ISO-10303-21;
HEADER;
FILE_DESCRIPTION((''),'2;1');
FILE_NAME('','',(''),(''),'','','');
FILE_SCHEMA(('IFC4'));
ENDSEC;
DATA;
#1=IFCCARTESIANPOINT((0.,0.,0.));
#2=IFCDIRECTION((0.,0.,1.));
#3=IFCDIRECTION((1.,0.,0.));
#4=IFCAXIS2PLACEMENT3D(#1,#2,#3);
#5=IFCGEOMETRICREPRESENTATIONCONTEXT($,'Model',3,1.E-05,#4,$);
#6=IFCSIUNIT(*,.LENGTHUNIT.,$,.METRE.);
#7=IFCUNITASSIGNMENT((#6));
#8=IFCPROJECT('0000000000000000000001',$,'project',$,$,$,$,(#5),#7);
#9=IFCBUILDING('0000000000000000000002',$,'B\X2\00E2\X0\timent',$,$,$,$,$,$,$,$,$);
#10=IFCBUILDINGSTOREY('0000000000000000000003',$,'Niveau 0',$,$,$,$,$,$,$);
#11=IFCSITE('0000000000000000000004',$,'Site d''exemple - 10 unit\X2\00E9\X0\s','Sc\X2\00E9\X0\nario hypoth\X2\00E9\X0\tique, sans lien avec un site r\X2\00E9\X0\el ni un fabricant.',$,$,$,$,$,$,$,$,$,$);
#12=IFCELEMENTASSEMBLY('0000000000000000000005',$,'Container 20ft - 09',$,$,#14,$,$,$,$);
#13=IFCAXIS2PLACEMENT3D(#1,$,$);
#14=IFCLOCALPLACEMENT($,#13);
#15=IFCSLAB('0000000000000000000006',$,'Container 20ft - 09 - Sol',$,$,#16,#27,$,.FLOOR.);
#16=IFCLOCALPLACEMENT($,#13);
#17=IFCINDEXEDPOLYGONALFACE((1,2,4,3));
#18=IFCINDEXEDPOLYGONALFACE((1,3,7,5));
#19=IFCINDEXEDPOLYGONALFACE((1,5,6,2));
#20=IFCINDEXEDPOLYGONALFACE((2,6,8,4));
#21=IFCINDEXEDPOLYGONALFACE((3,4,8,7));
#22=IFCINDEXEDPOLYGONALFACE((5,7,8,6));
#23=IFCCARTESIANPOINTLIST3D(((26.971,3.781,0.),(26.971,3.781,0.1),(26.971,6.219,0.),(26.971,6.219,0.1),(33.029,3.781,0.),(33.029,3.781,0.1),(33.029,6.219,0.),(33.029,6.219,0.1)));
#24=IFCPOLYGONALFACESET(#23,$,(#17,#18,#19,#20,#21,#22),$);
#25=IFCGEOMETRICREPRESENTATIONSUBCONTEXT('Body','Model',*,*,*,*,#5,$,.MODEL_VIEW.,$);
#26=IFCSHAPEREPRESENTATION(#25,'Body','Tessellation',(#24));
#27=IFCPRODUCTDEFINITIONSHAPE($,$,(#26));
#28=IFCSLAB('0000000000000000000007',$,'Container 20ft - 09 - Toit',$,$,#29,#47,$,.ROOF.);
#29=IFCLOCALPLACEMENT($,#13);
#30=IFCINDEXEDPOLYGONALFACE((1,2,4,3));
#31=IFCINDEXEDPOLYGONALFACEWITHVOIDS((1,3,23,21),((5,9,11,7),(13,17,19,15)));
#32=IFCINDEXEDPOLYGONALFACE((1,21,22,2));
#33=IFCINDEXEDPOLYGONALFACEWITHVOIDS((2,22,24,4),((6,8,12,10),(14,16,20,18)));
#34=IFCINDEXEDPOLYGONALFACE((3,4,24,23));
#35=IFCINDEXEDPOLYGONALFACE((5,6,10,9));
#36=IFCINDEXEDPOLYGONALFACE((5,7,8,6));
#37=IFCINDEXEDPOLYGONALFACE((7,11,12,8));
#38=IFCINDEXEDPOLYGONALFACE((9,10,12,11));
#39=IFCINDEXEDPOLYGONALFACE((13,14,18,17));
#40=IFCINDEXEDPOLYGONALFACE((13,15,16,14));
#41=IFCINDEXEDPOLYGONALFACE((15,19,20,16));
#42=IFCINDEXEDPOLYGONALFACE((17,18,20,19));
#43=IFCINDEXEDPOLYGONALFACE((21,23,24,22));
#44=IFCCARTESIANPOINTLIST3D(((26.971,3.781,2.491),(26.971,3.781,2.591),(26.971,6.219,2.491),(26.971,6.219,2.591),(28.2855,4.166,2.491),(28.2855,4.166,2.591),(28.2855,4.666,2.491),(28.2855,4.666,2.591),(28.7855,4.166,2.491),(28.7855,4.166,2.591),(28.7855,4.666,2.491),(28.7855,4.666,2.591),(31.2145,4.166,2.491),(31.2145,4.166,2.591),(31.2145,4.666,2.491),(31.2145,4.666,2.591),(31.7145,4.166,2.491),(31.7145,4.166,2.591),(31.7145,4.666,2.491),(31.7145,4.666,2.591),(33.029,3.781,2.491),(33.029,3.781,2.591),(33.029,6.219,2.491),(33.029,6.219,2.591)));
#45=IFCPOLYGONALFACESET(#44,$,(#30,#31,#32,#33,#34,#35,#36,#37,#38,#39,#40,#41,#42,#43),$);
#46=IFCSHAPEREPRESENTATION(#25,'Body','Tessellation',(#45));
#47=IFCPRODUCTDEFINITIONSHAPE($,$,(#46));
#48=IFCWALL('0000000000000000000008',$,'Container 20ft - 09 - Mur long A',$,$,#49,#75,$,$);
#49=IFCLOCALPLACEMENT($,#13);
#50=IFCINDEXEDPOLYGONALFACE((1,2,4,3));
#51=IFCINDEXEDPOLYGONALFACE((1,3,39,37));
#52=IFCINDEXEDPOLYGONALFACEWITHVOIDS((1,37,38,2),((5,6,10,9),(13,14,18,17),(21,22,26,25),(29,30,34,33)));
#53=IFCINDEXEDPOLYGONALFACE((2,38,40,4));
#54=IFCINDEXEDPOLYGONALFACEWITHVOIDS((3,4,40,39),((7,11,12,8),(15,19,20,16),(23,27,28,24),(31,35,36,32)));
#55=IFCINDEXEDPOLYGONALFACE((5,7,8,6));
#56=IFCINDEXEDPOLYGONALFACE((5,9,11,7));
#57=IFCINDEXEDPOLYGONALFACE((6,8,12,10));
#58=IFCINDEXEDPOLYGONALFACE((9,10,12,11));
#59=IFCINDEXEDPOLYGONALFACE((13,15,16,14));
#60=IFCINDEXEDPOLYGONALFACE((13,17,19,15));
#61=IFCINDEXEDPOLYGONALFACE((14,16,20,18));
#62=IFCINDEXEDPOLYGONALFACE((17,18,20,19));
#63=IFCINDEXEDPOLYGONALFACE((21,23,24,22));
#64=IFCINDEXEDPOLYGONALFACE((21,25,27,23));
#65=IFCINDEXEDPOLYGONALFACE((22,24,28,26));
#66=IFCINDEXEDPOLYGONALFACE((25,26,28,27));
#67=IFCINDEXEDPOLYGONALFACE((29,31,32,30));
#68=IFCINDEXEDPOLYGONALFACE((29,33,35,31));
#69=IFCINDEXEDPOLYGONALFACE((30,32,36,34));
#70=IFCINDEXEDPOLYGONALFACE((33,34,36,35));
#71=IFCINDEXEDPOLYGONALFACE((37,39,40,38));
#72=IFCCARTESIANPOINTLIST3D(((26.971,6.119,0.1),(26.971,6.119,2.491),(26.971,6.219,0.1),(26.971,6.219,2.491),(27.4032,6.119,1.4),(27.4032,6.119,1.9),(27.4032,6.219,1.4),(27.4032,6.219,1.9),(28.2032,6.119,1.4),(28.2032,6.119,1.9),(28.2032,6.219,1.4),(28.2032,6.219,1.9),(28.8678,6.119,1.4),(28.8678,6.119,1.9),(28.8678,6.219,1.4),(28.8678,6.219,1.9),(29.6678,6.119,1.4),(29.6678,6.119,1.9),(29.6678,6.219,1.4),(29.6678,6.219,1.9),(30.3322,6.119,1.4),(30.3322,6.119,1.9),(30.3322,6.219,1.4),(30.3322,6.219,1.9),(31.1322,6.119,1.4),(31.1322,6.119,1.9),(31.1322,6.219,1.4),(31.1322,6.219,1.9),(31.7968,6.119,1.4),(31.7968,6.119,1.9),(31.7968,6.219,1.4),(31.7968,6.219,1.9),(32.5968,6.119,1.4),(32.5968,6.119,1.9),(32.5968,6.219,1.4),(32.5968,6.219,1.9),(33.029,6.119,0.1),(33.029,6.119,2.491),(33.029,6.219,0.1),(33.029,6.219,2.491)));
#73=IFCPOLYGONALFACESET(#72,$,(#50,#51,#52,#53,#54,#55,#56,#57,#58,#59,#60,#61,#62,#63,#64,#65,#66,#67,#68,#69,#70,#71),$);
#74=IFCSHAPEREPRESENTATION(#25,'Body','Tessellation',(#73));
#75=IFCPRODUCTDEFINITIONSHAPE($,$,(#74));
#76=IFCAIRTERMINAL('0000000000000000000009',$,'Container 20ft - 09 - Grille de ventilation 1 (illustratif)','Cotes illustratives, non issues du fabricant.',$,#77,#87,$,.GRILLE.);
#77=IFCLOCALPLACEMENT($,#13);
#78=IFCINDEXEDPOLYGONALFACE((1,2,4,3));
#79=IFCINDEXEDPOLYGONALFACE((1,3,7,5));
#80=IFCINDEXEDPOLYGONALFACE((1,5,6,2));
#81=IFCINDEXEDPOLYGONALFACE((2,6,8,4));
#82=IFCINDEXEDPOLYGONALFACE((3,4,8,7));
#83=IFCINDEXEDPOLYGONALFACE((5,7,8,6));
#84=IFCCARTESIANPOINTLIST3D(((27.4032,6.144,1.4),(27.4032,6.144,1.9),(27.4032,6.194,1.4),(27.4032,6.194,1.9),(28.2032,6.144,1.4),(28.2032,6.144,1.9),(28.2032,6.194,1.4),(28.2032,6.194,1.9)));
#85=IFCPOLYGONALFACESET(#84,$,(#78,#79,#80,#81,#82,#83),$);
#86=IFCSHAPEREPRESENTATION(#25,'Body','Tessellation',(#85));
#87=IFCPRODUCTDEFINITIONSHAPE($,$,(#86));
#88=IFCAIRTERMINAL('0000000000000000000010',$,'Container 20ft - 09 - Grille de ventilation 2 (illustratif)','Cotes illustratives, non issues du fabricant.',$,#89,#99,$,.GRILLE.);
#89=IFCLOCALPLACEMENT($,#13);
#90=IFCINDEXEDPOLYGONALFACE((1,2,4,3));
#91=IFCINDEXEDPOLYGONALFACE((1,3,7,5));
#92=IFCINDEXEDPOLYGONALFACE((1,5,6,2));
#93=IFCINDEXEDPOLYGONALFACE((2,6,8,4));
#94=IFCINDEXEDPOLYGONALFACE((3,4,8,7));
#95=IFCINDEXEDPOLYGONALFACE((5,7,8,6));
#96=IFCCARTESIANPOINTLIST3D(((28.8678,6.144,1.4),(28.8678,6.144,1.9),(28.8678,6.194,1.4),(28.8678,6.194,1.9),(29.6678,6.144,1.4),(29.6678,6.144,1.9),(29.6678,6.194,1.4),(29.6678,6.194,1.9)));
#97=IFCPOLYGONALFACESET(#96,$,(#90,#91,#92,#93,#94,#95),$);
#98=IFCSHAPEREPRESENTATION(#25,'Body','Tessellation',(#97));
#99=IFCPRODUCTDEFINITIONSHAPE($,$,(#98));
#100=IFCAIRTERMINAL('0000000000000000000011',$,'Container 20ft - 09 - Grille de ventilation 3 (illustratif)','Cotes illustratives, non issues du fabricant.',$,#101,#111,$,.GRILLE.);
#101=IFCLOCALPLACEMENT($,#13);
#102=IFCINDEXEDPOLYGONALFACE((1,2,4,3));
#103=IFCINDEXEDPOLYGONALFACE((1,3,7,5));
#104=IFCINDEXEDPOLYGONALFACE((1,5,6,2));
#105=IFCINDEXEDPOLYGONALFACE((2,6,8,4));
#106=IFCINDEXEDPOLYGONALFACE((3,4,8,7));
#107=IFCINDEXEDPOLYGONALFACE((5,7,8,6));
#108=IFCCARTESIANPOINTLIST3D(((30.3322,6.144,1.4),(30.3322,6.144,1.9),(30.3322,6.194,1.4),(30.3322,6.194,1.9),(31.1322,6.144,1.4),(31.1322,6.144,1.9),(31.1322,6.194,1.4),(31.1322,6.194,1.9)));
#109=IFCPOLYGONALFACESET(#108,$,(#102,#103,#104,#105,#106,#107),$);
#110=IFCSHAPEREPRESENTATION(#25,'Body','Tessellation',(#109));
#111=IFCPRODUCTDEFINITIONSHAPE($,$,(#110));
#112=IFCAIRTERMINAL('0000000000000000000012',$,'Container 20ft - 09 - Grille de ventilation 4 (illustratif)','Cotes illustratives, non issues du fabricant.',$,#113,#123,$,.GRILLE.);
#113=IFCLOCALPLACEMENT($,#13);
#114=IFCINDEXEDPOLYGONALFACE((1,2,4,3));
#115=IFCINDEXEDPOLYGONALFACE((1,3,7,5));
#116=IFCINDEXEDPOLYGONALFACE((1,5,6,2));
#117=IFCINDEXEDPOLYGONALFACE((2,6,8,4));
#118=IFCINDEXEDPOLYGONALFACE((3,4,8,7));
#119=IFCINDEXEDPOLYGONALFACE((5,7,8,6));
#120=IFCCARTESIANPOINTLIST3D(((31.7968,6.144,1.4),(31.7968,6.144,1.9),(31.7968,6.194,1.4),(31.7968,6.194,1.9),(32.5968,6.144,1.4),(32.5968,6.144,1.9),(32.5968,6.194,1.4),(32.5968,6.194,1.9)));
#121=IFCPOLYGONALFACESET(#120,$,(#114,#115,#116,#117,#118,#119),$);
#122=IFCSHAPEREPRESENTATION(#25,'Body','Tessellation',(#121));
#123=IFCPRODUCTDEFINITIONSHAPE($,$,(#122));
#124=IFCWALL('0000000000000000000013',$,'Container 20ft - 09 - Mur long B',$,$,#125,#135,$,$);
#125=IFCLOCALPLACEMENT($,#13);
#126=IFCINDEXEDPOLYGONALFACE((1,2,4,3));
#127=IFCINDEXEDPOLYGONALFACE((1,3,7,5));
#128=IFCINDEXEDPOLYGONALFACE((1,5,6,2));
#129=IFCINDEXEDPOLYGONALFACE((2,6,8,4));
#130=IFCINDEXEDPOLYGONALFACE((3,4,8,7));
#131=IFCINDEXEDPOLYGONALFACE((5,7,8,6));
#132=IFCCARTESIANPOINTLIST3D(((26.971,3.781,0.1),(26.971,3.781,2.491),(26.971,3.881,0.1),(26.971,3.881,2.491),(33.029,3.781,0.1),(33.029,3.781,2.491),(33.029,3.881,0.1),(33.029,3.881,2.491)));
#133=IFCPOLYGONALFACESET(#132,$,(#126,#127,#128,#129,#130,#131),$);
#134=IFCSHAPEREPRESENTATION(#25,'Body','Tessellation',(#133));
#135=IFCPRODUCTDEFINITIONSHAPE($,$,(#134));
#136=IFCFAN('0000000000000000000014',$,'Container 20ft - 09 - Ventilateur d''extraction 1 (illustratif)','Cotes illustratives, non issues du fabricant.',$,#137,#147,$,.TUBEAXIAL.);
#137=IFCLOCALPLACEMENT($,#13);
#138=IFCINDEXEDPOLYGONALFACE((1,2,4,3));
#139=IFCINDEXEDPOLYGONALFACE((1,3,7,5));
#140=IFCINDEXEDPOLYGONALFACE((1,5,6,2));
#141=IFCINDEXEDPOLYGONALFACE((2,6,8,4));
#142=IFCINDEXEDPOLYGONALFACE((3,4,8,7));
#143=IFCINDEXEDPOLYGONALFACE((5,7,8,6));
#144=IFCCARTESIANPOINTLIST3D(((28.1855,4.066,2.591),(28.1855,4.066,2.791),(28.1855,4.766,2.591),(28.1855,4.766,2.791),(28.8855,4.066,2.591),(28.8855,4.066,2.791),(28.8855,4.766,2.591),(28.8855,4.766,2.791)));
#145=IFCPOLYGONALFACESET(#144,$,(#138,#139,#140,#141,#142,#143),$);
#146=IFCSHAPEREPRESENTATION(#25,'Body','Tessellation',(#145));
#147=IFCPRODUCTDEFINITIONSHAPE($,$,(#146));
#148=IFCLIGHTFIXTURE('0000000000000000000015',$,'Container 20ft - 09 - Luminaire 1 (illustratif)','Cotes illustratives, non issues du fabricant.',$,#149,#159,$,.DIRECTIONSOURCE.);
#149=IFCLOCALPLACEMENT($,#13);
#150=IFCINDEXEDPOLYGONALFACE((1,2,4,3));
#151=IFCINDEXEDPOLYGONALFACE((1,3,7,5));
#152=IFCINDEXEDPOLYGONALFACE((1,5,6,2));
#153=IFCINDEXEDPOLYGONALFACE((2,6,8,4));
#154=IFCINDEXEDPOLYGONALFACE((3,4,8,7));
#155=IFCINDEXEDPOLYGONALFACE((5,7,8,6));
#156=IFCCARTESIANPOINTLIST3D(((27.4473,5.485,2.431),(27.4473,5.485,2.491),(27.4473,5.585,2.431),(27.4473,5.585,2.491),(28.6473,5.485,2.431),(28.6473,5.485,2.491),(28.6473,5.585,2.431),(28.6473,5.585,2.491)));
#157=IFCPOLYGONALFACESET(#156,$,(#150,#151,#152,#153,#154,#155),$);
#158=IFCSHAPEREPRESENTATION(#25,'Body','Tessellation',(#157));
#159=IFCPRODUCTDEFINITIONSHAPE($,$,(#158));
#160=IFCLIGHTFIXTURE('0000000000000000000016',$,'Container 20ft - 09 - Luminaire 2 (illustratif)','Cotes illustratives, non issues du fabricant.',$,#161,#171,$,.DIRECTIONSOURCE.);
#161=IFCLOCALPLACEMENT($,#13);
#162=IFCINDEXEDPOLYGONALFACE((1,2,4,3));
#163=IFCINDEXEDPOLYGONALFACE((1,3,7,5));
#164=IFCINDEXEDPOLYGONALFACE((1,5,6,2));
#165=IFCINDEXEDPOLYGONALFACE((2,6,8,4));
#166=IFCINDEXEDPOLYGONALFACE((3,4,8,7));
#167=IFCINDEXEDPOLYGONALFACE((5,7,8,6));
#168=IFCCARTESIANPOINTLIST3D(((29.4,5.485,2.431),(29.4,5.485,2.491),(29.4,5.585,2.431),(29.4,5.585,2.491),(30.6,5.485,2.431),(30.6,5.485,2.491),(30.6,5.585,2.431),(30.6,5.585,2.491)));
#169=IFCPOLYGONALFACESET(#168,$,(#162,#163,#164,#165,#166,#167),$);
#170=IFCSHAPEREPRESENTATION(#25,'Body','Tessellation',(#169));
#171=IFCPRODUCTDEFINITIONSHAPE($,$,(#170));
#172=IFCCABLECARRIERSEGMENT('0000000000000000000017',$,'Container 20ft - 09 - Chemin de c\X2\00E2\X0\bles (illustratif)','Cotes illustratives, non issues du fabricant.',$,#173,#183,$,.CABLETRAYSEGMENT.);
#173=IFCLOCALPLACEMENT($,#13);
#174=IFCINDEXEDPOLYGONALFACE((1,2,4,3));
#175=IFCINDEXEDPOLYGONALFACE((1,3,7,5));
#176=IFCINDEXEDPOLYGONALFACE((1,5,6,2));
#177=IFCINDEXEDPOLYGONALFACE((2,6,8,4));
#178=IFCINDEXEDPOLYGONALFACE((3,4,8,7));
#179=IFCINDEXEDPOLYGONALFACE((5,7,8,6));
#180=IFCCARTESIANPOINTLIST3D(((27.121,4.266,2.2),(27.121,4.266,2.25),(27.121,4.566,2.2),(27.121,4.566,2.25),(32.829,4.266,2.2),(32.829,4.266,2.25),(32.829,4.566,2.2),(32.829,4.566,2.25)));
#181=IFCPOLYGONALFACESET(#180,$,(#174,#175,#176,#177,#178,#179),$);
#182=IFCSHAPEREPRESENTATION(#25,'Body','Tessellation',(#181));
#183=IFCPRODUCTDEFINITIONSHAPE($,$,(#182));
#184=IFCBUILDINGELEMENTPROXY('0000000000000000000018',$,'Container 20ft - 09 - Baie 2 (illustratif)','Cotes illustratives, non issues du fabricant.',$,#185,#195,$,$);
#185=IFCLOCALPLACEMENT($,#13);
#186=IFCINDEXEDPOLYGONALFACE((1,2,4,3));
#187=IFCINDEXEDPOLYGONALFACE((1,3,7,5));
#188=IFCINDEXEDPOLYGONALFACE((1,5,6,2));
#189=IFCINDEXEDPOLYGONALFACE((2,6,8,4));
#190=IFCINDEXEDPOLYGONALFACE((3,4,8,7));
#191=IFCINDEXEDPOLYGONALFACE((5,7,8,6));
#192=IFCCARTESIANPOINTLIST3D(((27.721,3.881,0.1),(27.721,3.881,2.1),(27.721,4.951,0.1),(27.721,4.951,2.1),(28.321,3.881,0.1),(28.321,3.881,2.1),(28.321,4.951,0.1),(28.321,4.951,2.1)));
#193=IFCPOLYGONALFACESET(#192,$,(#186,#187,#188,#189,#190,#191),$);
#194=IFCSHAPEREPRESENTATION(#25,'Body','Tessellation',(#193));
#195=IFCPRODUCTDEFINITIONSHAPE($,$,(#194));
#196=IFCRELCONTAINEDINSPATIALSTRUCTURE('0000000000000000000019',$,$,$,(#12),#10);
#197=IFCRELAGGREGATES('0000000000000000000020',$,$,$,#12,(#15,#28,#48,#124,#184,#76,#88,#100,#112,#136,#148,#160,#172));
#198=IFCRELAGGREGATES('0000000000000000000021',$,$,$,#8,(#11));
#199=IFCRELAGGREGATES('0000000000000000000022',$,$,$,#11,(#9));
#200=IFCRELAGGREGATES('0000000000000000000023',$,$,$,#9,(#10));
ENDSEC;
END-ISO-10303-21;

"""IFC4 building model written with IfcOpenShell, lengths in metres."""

from ifc_helpers import new_model, si_unit, frame, origin_with_axes, place, context, subcontext, project, spatial, rectangle, extrude, element, fill, aggregate, save


model = new_model("IFC4")

# Units and contexts
model_context = context("Model", 3, precision=1e-05, world=origin_with_axes())
body_context = subcontext(model_context, "Body", "Model", "MODEL_VIEW")
ifc_project = project(units=[si_unit("LENGTHUNIT", "METRE")], contexts=[model_context])

# Site, building, storey
site = spatial("IfcSite", under=ifc_project, Name="Site d'exemple - 10 unités", Description="Scénario hypothétique, sans lien avec un site réel ni un fabricant.")
building = spatial("IfcBuilding", under=site, Name="Bâtiment")
storey = spatial("IfcBuildingStorey", under=building, Name="Niveau 0")

# Element assembly, slabs, openings, walls, air terminals, fan, light fixtures, cable carrier segment, building element proxy
assembly = element("IfcElementAssembly", 1, inside=storey, Name="Container 20ft - 09")
slab_1_placement = place(None, frame((30.0, 5.0, 0.0), z_axis=(0.0, 0.0, 1.0), x_axis=(1.0, 0.0, 0.0)))
slab_1 = element("IfcSlab", 2, at=slab_1_placement, Name="Container 20ft - 09 - Sol", PredefinedType="FLOOR", context=body_context, shape_type="SweptSolid", body=[
    extrude(rectangle(XDim=6.058, YDim=2.438), origin_with_axes(), (0.0, 0.0, 1.0), 0.1),
])
slab_2_placement = place(None, frame((30.0, 5.0, 2.491), z_axis=(0.0, 0.0, 1.0), x_axis=(1.0, 0.0, 0.0)))
slab_2 = element("IfcSlab", 3, at=slab_2_placement, Name="Container 20ft - 09 - Toit", PredefinedType="ROOF", context=body_context, shape_type="SweptSolid", body=[
    extrude(rectangle(XDim=6.058, YDim=2.438), origin_with_axes(), (0.0, 0.0, 1.0), 0.1),
])
opening_1_placement = place(None, frame((28.5355, 4.416, 2.441), z_axis=(0.0, 0.0, 1.0), x_axis=(1.0, 0.0, 0.0)))
element("IfcOpeningElement", 4, at=opening_1_placement, cuts=slab_2, PredefinedType="OPENING", context=body_context, shape_type="SweptSolid", body=[
    extrude(rectangle(XDim=0.5, YDim=0.5), origin_with_axes(), (0.0, 0.0, 1.0), 0.2),
])
opening_2_placement = place(None, frame((31.4645, 4.416, 2.441), z_axis=(0.0, 0.0, 1.0), x_axis=(1.0, 0.0, 0.0)))
element("IfcOpeningElement", 5, at=opening_2_placement, cuts=slab_2, PredefinedType="OPENING", context=body_context, shape_type="SweptSolid", body=[
    extrude(rectangle(XDim=0.5, YDim=0.5), origin_with_axes(), (0.0, 0.0, 1.0), 0.2),
])
wall_1_placement = place(None, frame((30.0, 6.169, 0.1), z_axis=(0.0, 0.0, 1.0), x_axis=(1.0, 0.0, 0.0)))
wall_1 = element("IfcWall", 6, at=wall_1_placement, Name="Container 20ft - 09 - Mur long A", context=body_context, shape_type="SweptSolid", body=[
    extrude(rectangle(XDim=6.058, YDim=0.1), origin_with_axes(), (0.0, 0.0, 1.0), 2.391),
])
opening_3_placement = place(None, frame((27.8032, 6.169, 1.4), z_axis=(0.0, 0.0, 1.0), x_axis=(1.0, 0.0, 0.0)))
opening_3 = element("IfcOpeningElement", 7, at=opening_3_placement, cuts=wall_1, PredefinedType="OPENING", context=body_context, shape_type="SweptSolid", body=[
    extrude(rectangle(XDim=0.8, YDim=0.2), origin_with_axes(), (0.0, 0.0, 1.0), 0.5),
])
opening_4_placement = place(None, frame((29.2677, 6.169, 1.4), z_axis=(0.0, 0.0, 1.0), x_axis=(1.0, 0.0, 0.0)))
opening_4 = element("IfcOpeningElement", 8, at=opening_4_placement, cuts=wall_1, PredefinedType="OPENING", context=body_context, shape_type="SweptSolid", body=[
    extrude(rectangle(XDim=0.8, YDim=0.2), origin_with_axes(), (0.0, 0.0, 1.0), 0.5),
])
opening_5_placement = place(None, frame((30.7323, 6.169, 1.4), z_axis=(0.0, 0.0, 1.0), x_axis=(1.0, 0.0, 0.0)))
opening_5 = element("IfcOpeningElement", 9, at=opening_5_placement, cuts=wall_1, PredefinedType="OPENING", context=body_context, shape_type="SweptSolid", body=[
    extrude(rectangle(XDim=0.8, YDim=0.2), origin_with_axes(), (0.0, 0.0, 1.0), 0.5),
])
opening_6_placement = place(None, frame((32.1968, 6.169, 1.4), z_axis=(0.0, 0.0, 1.0), x_axis=(1.0, 0.0, 0.0)))
opening_6 = element("IfcOpeningElement", 10, at=opening_6_placement, cuts=wall_1, PredefinedType="OPENING", context=body_context, shape_type="SweptSolid", body=[
    extrude(rectangle(XDim=0.8, YDim=0.2), origin_with_axes(), (0.0, 0.0, 1.0), 0.5),
])
air_terminal_1_placement = place(None, frame((27.8032, 6.169, 1.4), z_axis=(0.0, 0.0, 1.0), x_axis=(1.0, 0.0, 0.0)))
air_terminal_1 = element("IfcAirTerminal", 11, at=air_terminal_1_placement, Name="Container 20ft - 09 - Grille de ventilation 1 (illustratif)", Description="Cotes illustratives, non issues du fabricant.", PredefinedType="GRILLE", context=body_context, shape_type="SweptSolid", body=[
    extrude(rectangle(XDim=0.8, YDim=0.05), origin_with_axes(), (0.0, 0.0, 1.0), 0.5),
])
fill(opening_3, air_terminal_1)
air_terminal_2_placement = place(None, frame((29.2677, 6.169, 1.4), z_axis=(0.0, 0.0, 1.0), x_axis=(1.0, 0.0, 0.0)))
air_terminal_2 = element("IfcAirTerminal", 12, at=air_terminal_2_placement, Name="Container 20ft - 09 - Grille de ventilation 2 (illustratif)", Description="Cotes illustratives, non issues du fabricant.", PredefinedType="GRILLE", context=body_context, shape_type="SweptSolid", body=[
    extrude(rectangle(XDim=0.8, YDim=0.05), origin_with_axes(), (0.0, 0.0, 1.0), 0.5),
])
fill(opening_4, air_terminal_2)
air_terminal_3_placement = place(None, frame((30.7323, 6.169, 1.4), z_axis=(0.0, 0.0, 1.0), x_axis=(1.0, 0.0, 0.0)))
air_terminal_3 = element("IfcAirTerminal", 13, at=air_terminal_3_placement, Name="Container 20ft - 09 - Grille de ventilation 3 (illustratif)", Description="Cotes illustratives, non issues du fabricant.", PredefinedType="GRILLE", context=body_context, shape_type="SweptSolid", body=[
    extrude(rectangle(XDim=0.8, YDim=0.05), origin_with_axes(), (0.0, 0.0, 1.0), 0.5),
])
fill(opening_5, air_terminal_3)
air_terminal_4_placement = place(None, frame((32.1968, 6.169, 1.4), z_axis=(0.0, 0.0, 1.0), x_axis=(1.0, 0.0, 0.0)))
air_terminal_4 = element("IfcAirTerminal", 14, at=air_terminal_4_placement, Name="Container 20ft - 09 - Grille de ventilation 4 (illustratif)", Description="Cotes illustratives, non issues du fabricant.", PredefinedType="GRILLE", context=body_context, shape_type="SweptSolid", body=[
    extrude(rectangle(XDim=0.8, YDim=0.05), origin_with_axes(), (0.0, 0.0, 1.0), 0.5),
])
fill(opening_6, air_terminal_4)
wall_2_placement = place(None, frame((30.0, 3.831, 0.1), z_axis=(0.0, 0.0, 1.0), x_axis=(1.0, 0.0, 0.0)))
wall_2 = element("IfcWall", 15, at=wall_2_placement, Name="Container 20ft - 09 - Mur long B", context=body_context, shape_type="SweptSolid", body=[
    extrude(rectangle(XDim=6.058, YDim=0.1), origin_with_axes(), (0.0, 0.0, 1.0), 2.391),
])
fan_placement = place(None, frame((28.5355, 4.416, 2.591), z_axis=(0.0, 0.0, 1.0), x_axis=(1.0, 0.0, 0.0)))
fan = element("IfcFan", 16, at=fan_placement, Name="Container 20ft - 09 - Ventilateur d'extraction 1 (illustratif)", Description="Cotes illustratives, non issues du fabricant.", PredefinedType="TUBEAXIAL", context=body_context, shape_type="SweptSolid", body=[
    extrude(rectangle(XDim=0.7, YDim=0.7), origin_with_axes(), (0.0, 0.0, 1.0), 0.2),
])
light_fixture_1_placement = place(None, frame((28.0473, 5.535, 2.431), z_axis=(0.0, 0.0, 1.0), x_axis=(1.0, 0.0, 0.0)))
light_fixture_1 = element("IfcLightFixture", 17, at=light_fixture_1_placement, Name="Container 20ft - 09 - Luminaire 1 (illustratif)", Description="Cotes illustratives, non issues du fabricant.", PredefinedType="DIRECTIONSOURCE", context=body_context, shape_type="SweptSolid", body=[
    extrude(rectangle(XDim=1.2, YDim=0.1), origin_with_axes(), (0.0, 0.0, 1.0), 0.06),
])
light_fixture_2_placement = place(None, frame((30.0, 5.535, 2.431), z_axis=(0.0, 0.0, 1.0), x_axis=(1.0, 0.0, 0.0)))
light_fixture_2 = element("IfcLightFixture", 18, at=light_fixture_2_placement, Name="Container 20ft - 09 - Luminaire 2 (illustratif)", Description="Cotes illustratives, non issues du fabricant.", PredefinedType="DIRECTIONSOURCE", context=body_context, shape_type="SweptSolid", body=[
    extrude(rectangle(XDim=1.2, YDim=0.1), origin_with_axes(), (0.0, 0.0, 1.0), 0.06),
])
cable_carrier_segment_placement = place(None, frame((29.975, 4.416, 2.2), z_axis=(0.0, 0.0, 1.0), x_axis=(1.0, 0.0, 0.0)))
cable_carrier_segment = element("IfcCableCarrierSegment", 19, at=cable_carrier_segment_placement, Name="Container 20ft - 09 - Chemin de câbles (illustratif)", Description="Cotes illustratives, non issues du fabricant.", PredefinedType="CABLETRAYSEGMENT", context=body_context, shape_type="SweptSolid", body=[
    extrude(rectangle(XDim=5.708, YDim=0.3), origin_with_axes(), (0.0, 0.0, 1.0), 0.05),
])
proxy_1_placement = place(None, frame((28.021, 4.416, 0.1), z_axis=(0.0, 0.0, 1.0), x_axis=(1.0, 0.0, 0.0)))
proxy_1 = element("IfcBuildingElementProxy", 20, at=proxy_1_placement, Name="Container 20ft - 09 - Baie 2 (illustratif)", Description="Cotes illustratives, non issues du fabricant.", context=body_context, shape_type="SweptSolid", body=[
    extrude(rectangle(XDim=0.6, YDim=1.07), origin_with_axes(), (0.0, 0.0, 1.0), 2.0),
])
aggregate(assembly, [slab_1, slab_2, wall_1, wall_2, proxy_1, air_terminal_1, air_terminal_2, air_terminal_3, air_terminal_4, fan, light_fixture_1, light_fixture_2, cable_carrier_segment])

save(model, "model.ifc")
